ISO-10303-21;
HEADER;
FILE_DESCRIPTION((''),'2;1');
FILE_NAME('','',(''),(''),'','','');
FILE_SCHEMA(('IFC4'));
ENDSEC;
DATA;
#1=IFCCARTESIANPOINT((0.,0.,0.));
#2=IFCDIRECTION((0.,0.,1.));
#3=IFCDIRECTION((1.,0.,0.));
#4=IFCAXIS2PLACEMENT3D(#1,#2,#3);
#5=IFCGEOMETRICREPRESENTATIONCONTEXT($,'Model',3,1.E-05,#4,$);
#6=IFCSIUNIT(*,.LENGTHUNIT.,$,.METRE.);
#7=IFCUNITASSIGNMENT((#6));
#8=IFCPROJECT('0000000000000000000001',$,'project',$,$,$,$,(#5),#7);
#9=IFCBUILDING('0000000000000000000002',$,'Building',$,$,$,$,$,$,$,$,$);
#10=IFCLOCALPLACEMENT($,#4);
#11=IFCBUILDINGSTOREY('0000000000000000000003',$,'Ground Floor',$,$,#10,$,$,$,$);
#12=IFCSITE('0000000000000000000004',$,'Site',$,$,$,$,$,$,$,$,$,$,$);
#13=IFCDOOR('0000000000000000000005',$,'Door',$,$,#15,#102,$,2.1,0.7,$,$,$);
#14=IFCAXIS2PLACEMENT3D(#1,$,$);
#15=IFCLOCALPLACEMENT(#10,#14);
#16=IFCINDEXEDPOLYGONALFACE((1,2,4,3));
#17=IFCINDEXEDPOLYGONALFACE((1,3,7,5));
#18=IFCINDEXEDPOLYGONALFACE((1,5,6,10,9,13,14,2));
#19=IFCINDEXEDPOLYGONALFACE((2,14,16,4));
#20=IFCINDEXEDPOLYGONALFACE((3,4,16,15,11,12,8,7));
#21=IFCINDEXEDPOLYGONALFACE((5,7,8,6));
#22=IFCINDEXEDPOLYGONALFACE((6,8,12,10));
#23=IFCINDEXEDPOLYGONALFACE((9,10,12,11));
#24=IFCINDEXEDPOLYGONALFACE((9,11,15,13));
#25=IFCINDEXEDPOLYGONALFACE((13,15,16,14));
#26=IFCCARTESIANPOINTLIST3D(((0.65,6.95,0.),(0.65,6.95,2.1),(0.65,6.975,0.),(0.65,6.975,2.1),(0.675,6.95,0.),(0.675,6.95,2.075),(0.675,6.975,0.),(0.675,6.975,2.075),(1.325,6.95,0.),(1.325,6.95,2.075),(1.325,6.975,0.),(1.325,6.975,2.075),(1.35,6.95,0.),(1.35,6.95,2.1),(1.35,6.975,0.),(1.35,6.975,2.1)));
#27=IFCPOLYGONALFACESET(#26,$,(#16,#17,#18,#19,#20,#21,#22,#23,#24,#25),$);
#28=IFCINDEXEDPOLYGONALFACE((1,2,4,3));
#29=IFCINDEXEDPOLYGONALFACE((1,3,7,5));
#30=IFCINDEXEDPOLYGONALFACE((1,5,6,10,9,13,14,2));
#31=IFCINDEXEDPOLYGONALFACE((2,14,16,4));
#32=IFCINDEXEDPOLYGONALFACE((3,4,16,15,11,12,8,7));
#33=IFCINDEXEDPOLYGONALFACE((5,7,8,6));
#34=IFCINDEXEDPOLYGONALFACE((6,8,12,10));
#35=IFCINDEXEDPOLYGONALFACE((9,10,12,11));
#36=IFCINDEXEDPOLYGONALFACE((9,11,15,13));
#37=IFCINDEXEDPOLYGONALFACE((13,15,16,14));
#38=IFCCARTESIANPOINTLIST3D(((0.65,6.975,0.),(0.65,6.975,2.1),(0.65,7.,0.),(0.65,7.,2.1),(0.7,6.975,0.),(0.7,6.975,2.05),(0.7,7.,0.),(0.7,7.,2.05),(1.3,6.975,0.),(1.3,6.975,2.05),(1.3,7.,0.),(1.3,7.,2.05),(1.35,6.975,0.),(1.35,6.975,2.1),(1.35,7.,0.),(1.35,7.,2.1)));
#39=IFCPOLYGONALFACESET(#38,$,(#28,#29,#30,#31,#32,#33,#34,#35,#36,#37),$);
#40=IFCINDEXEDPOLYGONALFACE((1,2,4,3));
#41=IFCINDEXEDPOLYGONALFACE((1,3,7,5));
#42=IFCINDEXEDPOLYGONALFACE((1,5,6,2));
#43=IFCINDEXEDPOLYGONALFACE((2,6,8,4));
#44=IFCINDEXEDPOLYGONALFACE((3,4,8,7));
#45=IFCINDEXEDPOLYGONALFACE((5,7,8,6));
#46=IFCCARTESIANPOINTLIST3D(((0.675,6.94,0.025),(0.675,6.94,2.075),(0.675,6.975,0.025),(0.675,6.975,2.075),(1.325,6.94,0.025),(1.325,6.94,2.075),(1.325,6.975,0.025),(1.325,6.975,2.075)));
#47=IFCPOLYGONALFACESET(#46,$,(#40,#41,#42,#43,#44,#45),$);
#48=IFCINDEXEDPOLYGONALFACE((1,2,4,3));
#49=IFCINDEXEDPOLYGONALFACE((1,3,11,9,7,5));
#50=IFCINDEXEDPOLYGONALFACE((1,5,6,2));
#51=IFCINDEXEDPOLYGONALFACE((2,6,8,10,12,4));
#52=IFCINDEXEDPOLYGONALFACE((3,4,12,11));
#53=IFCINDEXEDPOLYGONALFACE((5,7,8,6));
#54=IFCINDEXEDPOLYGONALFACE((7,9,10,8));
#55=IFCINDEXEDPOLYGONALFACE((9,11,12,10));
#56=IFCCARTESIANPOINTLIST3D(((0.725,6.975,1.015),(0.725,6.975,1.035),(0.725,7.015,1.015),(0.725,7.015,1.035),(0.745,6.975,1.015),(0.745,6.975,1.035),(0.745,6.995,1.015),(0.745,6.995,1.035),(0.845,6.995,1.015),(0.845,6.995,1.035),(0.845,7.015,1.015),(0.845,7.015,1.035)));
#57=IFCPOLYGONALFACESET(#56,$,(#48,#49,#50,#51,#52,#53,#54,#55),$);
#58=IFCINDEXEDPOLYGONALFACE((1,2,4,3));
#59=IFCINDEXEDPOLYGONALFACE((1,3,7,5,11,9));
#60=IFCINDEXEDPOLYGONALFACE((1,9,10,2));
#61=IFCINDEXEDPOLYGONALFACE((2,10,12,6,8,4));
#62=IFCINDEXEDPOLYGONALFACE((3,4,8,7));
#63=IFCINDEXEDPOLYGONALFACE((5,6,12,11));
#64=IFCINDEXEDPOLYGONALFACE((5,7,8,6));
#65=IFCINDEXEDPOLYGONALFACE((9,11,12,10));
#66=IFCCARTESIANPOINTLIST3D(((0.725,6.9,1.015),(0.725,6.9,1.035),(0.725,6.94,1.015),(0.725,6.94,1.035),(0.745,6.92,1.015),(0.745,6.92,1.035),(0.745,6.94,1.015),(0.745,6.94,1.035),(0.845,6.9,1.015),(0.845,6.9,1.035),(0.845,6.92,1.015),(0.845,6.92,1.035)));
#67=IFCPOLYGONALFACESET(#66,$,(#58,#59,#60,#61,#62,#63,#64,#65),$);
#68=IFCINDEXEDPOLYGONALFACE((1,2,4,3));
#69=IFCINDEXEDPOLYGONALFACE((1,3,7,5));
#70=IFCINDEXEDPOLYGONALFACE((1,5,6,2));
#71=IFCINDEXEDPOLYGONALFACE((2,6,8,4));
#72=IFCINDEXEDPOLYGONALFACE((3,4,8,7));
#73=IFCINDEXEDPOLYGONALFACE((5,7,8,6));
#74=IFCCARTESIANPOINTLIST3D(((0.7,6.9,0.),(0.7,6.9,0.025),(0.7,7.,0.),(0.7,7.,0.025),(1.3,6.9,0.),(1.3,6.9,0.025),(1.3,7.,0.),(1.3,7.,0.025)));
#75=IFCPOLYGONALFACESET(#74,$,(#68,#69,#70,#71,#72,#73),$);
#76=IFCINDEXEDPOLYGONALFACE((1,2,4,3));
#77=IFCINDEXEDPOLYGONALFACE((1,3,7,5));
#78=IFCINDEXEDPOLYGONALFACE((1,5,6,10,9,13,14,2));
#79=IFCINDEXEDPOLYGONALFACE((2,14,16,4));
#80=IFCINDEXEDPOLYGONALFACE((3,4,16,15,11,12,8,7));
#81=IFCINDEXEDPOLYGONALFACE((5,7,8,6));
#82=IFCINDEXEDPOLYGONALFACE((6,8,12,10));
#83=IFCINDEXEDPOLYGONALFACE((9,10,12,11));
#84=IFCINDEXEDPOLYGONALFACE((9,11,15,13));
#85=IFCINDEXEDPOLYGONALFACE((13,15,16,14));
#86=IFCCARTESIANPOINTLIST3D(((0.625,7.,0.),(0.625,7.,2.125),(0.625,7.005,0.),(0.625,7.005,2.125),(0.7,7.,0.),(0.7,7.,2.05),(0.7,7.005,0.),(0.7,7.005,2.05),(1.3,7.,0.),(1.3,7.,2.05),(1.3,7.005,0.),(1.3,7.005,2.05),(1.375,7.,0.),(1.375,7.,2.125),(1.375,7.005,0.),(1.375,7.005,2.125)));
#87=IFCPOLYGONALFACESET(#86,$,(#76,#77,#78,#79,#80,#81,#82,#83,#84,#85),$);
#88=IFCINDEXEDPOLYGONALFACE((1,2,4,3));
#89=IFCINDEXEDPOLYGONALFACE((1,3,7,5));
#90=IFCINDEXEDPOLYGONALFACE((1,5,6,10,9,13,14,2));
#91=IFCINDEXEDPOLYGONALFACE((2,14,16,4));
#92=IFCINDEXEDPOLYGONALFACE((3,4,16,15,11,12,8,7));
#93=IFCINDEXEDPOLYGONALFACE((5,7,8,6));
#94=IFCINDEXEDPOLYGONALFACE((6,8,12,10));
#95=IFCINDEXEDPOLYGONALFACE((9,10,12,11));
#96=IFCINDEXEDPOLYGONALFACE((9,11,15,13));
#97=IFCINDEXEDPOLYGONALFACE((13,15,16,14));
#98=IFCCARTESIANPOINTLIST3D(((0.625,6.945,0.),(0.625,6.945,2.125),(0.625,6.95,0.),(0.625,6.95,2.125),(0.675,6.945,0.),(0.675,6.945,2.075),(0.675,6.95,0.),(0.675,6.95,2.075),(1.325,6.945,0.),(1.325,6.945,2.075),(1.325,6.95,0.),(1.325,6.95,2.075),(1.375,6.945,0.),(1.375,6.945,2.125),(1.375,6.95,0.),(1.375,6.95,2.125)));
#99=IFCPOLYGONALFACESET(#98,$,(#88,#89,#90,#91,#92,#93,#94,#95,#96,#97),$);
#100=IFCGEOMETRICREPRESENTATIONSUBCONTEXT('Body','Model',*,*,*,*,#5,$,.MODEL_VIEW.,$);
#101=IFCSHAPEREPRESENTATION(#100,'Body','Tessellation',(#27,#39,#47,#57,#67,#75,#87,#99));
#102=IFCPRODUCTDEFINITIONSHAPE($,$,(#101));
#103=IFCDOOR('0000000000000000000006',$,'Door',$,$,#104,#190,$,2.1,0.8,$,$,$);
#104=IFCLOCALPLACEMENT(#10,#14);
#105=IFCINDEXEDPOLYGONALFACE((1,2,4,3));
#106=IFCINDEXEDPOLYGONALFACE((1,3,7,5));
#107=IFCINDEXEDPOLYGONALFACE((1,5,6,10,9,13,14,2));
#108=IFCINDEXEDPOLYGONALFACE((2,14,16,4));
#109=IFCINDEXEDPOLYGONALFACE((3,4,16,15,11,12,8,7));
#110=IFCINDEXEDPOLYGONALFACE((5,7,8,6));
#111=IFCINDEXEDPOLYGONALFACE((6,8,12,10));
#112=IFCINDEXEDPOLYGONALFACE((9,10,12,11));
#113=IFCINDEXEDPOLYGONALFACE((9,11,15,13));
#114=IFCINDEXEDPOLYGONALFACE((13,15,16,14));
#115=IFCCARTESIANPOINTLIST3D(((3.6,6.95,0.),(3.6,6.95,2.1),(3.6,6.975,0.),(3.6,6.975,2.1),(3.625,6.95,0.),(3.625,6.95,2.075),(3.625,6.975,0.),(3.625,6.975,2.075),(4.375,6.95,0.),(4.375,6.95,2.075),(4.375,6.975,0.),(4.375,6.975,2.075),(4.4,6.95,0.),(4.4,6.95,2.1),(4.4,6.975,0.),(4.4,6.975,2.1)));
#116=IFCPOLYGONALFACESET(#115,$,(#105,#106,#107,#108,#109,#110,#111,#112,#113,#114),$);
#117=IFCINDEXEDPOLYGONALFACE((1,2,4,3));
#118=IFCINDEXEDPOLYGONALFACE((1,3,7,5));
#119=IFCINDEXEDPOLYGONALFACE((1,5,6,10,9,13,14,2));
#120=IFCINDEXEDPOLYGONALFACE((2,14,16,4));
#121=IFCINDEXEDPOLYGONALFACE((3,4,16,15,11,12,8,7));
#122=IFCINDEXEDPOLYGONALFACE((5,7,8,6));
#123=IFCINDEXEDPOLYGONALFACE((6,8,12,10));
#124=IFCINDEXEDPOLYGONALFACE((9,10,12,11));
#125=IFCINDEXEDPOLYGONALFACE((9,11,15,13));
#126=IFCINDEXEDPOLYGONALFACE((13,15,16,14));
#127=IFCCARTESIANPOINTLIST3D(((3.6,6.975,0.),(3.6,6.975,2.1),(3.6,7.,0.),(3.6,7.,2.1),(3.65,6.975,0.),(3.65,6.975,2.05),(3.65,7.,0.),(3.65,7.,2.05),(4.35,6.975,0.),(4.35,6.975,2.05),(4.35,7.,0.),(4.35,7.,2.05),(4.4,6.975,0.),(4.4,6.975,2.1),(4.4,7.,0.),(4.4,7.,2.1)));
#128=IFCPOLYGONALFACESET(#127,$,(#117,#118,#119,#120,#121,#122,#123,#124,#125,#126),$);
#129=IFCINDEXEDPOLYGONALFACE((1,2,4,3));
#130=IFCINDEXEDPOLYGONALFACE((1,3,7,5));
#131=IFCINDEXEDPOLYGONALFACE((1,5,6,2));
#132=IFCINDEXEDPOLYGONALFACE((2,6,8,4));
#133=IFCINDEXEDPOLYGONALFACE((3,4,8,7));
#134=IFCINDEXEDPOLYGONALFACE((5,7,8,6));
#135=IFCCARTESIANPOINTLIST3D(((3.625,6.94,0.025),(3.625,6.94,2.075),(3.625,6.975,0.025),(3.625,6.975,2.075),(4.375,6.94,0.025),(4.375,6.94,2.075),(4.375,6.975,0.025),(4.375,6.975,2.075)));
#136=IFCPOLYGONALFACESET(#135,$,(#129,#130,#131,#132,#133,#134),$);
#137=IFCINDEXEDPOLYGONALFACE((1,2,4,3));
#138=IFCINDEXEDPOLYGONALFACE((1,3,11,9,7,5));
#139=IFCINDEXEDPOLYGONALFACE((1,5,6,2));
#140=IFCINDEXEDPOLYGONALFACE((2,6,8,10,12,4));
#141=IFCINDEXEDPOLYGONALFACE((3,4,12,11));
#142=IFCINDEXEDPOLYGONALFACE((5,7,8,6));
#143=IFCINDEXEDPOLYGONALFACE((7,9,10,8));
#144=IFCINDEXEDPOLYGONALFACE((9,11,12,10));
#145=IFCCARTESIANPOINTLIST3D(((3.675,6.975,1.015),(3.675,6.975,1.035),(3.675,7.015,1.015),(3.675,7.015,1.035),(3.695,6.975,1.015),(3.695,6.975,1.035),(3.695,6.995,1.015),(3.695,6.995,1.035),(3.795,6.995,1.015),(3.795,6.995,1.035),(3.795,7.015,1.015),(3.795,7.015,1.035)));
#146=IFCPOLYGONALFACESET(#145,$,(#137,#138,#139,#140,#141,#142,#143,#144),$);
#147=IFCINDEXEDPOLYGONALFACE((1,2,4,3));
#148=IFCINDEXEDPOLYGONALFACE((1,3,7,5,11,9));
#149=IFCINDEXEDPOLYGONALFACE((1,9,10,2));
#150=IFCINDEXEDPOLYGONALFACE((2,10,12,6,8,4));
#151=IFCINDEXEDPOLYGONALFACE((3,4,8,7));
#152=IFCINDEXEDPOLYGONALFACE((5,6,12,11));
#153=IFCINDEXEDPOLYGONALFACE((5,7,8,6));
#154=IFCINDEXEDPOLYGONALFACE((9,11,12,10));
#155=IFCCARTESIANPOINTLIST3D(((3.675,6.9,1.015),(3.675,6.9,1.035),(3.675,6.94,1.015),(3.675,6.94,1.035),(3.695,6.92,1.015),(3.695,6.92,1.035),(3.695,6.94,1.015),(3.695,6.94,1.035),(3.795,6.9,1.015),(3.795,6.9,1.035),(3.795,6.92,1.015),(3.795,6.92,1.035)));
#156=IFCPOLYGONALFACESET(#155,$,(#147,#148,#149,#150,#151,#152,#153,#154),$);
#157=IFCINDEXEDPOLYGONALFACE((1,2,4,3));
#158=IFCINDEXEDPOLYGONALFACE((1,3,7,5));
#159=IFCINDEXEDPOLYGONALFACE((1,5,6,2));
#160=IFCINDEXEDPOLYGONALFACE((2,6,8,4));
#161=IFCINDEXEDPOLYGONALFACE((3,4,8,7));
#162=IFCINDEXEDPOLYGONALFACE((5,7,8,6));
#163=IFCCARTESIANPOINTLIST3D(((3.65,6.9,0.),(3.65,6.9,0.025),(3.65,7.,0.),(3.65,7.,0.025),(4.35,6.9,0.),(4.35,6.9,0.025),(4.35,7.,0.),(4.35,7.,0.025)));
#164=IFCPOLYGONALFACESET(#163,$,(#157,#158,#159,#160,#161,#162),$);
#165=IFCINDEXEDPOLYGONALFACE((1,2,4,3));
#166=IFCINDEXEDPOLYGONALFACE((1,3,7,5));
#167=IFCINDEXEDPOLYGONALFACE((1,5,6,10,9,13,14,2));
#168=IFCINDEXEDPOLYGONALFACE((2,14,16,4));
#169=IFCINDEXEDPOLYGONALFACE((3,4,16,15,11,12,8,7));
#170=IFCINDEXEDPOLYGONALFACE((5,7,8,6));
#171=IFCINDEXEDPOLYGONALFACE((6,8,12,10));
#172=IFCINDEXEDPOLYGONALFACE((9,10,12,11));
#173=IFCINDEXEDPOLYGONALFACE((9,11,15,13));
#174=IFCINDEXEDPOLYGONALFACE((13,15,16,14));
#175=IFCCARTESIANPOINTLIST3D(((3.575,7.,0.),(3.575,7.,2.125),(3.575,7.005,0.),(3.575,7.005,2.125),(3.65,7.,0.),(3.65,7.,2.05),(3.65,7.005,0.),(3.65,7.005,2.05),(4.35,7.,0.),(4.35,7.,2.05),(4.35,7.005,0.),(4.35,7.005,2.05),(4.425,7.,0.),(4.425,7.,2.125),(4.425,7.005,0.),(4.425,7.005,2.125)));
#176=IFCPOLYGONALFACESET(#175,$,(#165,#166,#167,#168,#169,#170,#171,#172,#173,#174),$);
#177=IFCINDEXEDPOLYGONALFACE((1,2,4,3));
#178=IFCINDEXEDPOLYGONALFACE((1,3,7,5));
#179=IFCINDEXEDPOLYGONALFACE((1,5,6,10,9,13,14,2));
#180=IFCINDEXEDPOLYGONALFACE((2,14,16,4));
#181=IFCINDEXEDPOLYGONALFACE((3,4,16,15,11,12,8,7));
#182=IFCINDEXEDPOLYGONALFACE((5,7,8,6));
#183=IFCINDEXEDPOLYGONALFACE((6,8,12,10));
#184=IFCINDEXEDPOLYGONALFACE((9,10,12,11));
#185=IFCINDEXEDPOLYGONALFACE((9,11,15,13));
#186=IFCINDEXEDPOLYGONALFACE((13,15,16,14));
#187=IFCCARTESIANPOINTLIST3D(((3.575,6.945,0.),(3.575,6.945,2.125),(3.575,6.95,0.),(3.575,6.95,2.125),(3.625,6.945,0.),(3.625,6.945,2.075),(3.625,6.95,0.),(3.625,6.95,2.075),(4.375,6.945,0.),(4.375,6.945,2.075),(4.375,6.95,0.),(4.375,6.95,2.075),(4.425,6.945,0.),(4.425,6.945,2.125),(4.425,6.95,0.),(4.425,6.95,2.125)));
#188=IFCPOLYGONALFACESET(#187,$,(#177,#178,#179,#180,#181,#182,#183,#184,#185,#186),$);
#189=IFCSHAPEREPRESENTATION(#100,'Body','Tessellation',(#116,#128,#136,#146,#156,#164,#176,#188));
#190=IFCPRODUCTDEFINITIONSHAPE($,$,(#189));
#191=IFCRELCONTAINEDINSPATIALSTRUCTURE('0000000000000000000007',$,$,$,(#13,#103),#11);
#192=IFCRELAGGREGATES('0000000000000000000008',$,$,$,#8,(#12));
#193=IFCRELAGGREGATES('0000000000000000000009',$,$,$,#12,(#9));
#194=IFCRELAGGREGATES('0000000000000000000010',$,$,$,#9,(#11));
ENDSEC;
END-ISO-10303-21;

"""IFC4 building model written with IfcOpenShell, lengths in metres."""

from ifc_helpers import new_model, si_unit, frame, origin_with_axes, place, context, subcontext, project, spatial, line, indexed_curve, outline, extrude, element, save


model = new_model("IFC4")

# Units and contexts
model_context = context("Model", 3, precision=1e-05, world=origin_with_axes())
body_context = subcontext(model_context, "Body", "Model", "MODEL_VIEW")
ifc_project = project(units=[si_unit("LENGTHUNIT", "METRE")], contexts=[model_context])

# Site, building, storey
site = spatial("IfcSite", under=ifc_project, Name="Site")
building = spatial("IfcBuilding", under=site, Name="Building")
storey_placement = place(None, origin_with_axes())
storey = spatial("IfcBuildingStorey", under=building, at=storey_placement, Name="Ground Floor")

# Doors
door_1_placement = place(storey_placement, frame((1.35, 7.0, 0.0), z_axis=(0.0, 0.0, 1.0), x_axis=(-1.0, 0.0, 0.0)))
element("IfcDoor", 1, at=door_1_placement, inside=storey, Name="Door", OverallHeight=2.1, OverallWidth=0.7, context=body_context, shape_type="SweptSolid", body=[
    extrude(outline(indexed_curve([(0.0, 0.0), (0.0, 2.1), (0.7, 2.1), (0.7, 0.0), (0.675, 0.0), (0.675, 2.075), (0.025, 2.075), (0.025, 0.0)], segments=[line(1, 2, 3, 4, 5, 6, 7, 8, 1)])), frame((0.0, 0.025, 0.0), z_axis=(0.0, -1.0, 0.0), x_axis=(1.0, 0.0, 0.0)), (0.0, 0.0, -1.0), 0.025),
    extrude(outline(indexed_curve([(0.0, 0.0), (0.0, 2.1), (0.7, 2.1), (0.7, 0.0), (0.65, 0.0), (0.65, 2.05), (0.05, 2.05), (0.05, 0.0)], segments=[line(1, 2, 3, 4, 5, 6, 7, 8, 1)])), frame((0.0, 0.0, 0.0), z_axis=(0.0, -1.0, 0.0), x_axis=(1.0, 0.0, 0.0)), (0.0, 0.0, -1.0), 0.025),
    extrude(outline(indexed_curve([(0.0, 0.0), (0.65, 0.0), (0.65, 0.035), (0.0, 0.035)], segments=[line(1, 2, 3, 4, 1)])), frame((0.025, 0.025, 0.025), z_axis=(0.0, 0.0, 1.0), x_axis=(1.0, 0.0, 0.0)), (0.0, 0.0, 1.0), 2.05),
    extrude(outline(indexed_curve([(0.0, 0.0), (0.0, -0.04), (-0.12, -0.04), (-0.12, -0.02), (-0.02, -0.02), (-0.02, 0.0)], segments=[line(1, 2, 3, 4, 5, 6, 1)])), frame((0.625, 0.025, 1.015), z_axis=(0.0, 0.0, 1.0), x_axis=(1.0, 0.0, 0.0)), (0.0, 0.0, 1.0), 0.02),
    extrude(outline(indexed_curve([(0.0, 0.0), (0.0, 0.04), (-0.12, 0.04), (-0.12, 0.02), (-0.02, 0.02), (-0.02, 0.0)], segments=[line(1, 2, 3, 4, 5, 6, 1)])), frame((0.625, 0.06, 1.015), z_axis=(0.0, 0.0, 1.0), x_axis=(1.0, 0.0, 0.0)), (0.0, 0.0, 1.0), 0.02),
    extrude(outline(indexed_curve([(0.0, 0.0), (0.6, 0.0), (0.6, 0.1), (0.0, 0.1)], segments=[line(1, 2, 3, 4, 1)])), frame((0.05, 0.0, 0.0), z_axis=(0.0, 0.0, 1.0), x_axis=(1.0, 0.0, 0.0)), (0.0, 0.0, 1.0), 0.025),
    extrude(outline(indexed_curve([(0.0, 0.0), (0.0, 2.125), (0.75, 2.125), (0.75, 0.0), (0.675, 0.0), (0.675, 2.05), (0.075, 2.05), (0.075, 0.0)], segments=[line(1, 2, 3, 4, 5, 6, 7, 8, 1)])), frame((-0.025, -0.005, 0.0), z_axis=(0.0, -1.0, 0.0), x_axis=(1.0, 0.0, 0.0)), (0.0, 0.0, -1.0), 0.005),
    extrude(outline(indexed_curve([(0.0, 0.0), (0.0, 2.125), (0.75, 2.125), (0.75, 0.0), (0.7, 0.0), (0.7, 2.075), (0.05, 2.075), (0.05, 0.0)], segments=[line(1, 2, 3, 4, 5, 6, 7, 8, 1)])), frame((-0.025, 0.05, 0.0), z_axis=(0.0, -1.0, 0.0), x_axis=(1.0, 0.0, 0.0)), (0.0, 0.0, -1.0), 0.005),
])
door_2_placement = place(storey_placement, frame((4.4, 7.0, 0.0), z_axis=(0.0, 0.0, 1.0), x_axis=(-1.0, 0.0, 0.0)))
element("IfcDoor", 2, at=door_2_placement, inside=storey, Name="Door", OverallHeight=2.1, OverallWidth=0.8, context=body_context, shape_type="SweptSolid", body=[
    extrude(outline(indexed_curve([(0.0, 0.0), (0.0, 2.1), (0.8, 2.1), (0.8, 0.0), (0.775, 0.0), (0.775, 2.075), (0.025, 2.075), (0.025, 0.0)], segments=[line(1, 2, 3, 4, 5, 6, 7, 8, 1)])), frame((0.0, 0.025, 0.0), z_axis=(0.0, -1.0, 0.0), x_axis=(1.0, 0.0, 0.0)), (0.0, 0.0, -1.0), 0.025),
    extrude(outline(indexed_curve([(0.0, 0.0), (0.0, 2.1), (0.8, 2.1), (0.8, 0.0), (0.75, 0.0), (0.75, 2.05), (0.05, 2.05), (0.05, 0.0)], segments=[line(1, 2, 3, 4, 5, 6, 7, 8, 1)])), frame((0.0, 0.0, 0.0), z_axis=(0.0, -1.0, 0.0), x_axis=(1.0, 0.0, 0.0)), (0.0, 0.0, -1.0), 0.025),
    extrude(outline(indexed_curve([(0.0, 0.0), (0.75, 0.0), (0.75, 0.035), (0.0, 0.035)], segments=[line(1, 2, 3, 4, 1)])), frame((0.025, 0.025, 0.025), z_axis=(0.0, 0.0, 1.0), x_axis=(1.0, 0.0, 0.0)), (0.0, 0.0, 1.0), 2.05),
    extrude(outline(indexed_curve([(0.0, 0.0), (0.0, -0.04), (-0.12, -0.04), (-0.12, -0.02), (-0.02, -0.02), (-0.02, 0.0)], segments=[line(1, 2, 3, 4, 5, 6, 1)])), frame((0.725, 0.025, 1.015), z_axis=(0.0, 0.0, 1.0), x_axis=(1.0, 0.0, 0.0)), (0.0, 0.0, 1.0), 0.02),
    extrude(outline(indexed_curve([(0.0, 0.0), (0.0, 0.04), (-0.12, 0.04), (-0.12, 0.02), (-0.02, 0.02), (-0.02, 0.0)], segments=[line(1, 2, 3, 4, 5, 6, 1)])), frame((0.725, 0.06, 1.015), z_axis=(0.0, 0.0, 1.0), x_axis=(1.0, 0.0, 0.0)), (0.0, 0.0, 1.0), 0.02),
    extrude(outline(indexed_curve([(0.0, 0.0), (0.7, 0.0), (0.7, 0.1), (0.0, 0.1)], segments=[line(1, 2, 3, 4, 1)])), frame((0.05, 0.0, 0.0), z_axis=(0.0, 0.0, 1.0), x_axis=(1.0, 0.0, 0.0)), (0.0, 0.0, 1.0), 0.025),
    extrude(outline(indexed_curve([(0.0, 0.0), (0.0, 2.125), (0.85, 2.125), (0.85, 0.0), (0.775, 0.0), (0.775, 2.05), (0.075, 2.05), (0.075, 0.0)], segments=[line(1, 2, 3, 4, 5, 6, 7, 8, 1)])), frame((-0.025, -0.005, 0.0), z_axis=(0.0, -1.0, 0.0), x_axis=(1.0, 0.0, 0.0)), (0.0, 0.0, -1.0), 0.005),
    extrude(outline(indexed_curve([(0.0, 0.0), (0.0, 2.125), (0.85, 2.125), (0.85, 0.0), (0.8, 0.0), (0.8, 2.075), (0.05, 2.075), (0.05, 0.0)], segments=[line(1, 2, 3, 4, 5, 6, 7, 8, 1)])), frame((-0.025, 0.05, 0.0), z_axis=(0.0, -1.0, 0.0), x_axis=(1.0, 0.0, 0.0)), (0.0, 0.0, -1.0), 0.005),
])

save(model, "model.ifc")
